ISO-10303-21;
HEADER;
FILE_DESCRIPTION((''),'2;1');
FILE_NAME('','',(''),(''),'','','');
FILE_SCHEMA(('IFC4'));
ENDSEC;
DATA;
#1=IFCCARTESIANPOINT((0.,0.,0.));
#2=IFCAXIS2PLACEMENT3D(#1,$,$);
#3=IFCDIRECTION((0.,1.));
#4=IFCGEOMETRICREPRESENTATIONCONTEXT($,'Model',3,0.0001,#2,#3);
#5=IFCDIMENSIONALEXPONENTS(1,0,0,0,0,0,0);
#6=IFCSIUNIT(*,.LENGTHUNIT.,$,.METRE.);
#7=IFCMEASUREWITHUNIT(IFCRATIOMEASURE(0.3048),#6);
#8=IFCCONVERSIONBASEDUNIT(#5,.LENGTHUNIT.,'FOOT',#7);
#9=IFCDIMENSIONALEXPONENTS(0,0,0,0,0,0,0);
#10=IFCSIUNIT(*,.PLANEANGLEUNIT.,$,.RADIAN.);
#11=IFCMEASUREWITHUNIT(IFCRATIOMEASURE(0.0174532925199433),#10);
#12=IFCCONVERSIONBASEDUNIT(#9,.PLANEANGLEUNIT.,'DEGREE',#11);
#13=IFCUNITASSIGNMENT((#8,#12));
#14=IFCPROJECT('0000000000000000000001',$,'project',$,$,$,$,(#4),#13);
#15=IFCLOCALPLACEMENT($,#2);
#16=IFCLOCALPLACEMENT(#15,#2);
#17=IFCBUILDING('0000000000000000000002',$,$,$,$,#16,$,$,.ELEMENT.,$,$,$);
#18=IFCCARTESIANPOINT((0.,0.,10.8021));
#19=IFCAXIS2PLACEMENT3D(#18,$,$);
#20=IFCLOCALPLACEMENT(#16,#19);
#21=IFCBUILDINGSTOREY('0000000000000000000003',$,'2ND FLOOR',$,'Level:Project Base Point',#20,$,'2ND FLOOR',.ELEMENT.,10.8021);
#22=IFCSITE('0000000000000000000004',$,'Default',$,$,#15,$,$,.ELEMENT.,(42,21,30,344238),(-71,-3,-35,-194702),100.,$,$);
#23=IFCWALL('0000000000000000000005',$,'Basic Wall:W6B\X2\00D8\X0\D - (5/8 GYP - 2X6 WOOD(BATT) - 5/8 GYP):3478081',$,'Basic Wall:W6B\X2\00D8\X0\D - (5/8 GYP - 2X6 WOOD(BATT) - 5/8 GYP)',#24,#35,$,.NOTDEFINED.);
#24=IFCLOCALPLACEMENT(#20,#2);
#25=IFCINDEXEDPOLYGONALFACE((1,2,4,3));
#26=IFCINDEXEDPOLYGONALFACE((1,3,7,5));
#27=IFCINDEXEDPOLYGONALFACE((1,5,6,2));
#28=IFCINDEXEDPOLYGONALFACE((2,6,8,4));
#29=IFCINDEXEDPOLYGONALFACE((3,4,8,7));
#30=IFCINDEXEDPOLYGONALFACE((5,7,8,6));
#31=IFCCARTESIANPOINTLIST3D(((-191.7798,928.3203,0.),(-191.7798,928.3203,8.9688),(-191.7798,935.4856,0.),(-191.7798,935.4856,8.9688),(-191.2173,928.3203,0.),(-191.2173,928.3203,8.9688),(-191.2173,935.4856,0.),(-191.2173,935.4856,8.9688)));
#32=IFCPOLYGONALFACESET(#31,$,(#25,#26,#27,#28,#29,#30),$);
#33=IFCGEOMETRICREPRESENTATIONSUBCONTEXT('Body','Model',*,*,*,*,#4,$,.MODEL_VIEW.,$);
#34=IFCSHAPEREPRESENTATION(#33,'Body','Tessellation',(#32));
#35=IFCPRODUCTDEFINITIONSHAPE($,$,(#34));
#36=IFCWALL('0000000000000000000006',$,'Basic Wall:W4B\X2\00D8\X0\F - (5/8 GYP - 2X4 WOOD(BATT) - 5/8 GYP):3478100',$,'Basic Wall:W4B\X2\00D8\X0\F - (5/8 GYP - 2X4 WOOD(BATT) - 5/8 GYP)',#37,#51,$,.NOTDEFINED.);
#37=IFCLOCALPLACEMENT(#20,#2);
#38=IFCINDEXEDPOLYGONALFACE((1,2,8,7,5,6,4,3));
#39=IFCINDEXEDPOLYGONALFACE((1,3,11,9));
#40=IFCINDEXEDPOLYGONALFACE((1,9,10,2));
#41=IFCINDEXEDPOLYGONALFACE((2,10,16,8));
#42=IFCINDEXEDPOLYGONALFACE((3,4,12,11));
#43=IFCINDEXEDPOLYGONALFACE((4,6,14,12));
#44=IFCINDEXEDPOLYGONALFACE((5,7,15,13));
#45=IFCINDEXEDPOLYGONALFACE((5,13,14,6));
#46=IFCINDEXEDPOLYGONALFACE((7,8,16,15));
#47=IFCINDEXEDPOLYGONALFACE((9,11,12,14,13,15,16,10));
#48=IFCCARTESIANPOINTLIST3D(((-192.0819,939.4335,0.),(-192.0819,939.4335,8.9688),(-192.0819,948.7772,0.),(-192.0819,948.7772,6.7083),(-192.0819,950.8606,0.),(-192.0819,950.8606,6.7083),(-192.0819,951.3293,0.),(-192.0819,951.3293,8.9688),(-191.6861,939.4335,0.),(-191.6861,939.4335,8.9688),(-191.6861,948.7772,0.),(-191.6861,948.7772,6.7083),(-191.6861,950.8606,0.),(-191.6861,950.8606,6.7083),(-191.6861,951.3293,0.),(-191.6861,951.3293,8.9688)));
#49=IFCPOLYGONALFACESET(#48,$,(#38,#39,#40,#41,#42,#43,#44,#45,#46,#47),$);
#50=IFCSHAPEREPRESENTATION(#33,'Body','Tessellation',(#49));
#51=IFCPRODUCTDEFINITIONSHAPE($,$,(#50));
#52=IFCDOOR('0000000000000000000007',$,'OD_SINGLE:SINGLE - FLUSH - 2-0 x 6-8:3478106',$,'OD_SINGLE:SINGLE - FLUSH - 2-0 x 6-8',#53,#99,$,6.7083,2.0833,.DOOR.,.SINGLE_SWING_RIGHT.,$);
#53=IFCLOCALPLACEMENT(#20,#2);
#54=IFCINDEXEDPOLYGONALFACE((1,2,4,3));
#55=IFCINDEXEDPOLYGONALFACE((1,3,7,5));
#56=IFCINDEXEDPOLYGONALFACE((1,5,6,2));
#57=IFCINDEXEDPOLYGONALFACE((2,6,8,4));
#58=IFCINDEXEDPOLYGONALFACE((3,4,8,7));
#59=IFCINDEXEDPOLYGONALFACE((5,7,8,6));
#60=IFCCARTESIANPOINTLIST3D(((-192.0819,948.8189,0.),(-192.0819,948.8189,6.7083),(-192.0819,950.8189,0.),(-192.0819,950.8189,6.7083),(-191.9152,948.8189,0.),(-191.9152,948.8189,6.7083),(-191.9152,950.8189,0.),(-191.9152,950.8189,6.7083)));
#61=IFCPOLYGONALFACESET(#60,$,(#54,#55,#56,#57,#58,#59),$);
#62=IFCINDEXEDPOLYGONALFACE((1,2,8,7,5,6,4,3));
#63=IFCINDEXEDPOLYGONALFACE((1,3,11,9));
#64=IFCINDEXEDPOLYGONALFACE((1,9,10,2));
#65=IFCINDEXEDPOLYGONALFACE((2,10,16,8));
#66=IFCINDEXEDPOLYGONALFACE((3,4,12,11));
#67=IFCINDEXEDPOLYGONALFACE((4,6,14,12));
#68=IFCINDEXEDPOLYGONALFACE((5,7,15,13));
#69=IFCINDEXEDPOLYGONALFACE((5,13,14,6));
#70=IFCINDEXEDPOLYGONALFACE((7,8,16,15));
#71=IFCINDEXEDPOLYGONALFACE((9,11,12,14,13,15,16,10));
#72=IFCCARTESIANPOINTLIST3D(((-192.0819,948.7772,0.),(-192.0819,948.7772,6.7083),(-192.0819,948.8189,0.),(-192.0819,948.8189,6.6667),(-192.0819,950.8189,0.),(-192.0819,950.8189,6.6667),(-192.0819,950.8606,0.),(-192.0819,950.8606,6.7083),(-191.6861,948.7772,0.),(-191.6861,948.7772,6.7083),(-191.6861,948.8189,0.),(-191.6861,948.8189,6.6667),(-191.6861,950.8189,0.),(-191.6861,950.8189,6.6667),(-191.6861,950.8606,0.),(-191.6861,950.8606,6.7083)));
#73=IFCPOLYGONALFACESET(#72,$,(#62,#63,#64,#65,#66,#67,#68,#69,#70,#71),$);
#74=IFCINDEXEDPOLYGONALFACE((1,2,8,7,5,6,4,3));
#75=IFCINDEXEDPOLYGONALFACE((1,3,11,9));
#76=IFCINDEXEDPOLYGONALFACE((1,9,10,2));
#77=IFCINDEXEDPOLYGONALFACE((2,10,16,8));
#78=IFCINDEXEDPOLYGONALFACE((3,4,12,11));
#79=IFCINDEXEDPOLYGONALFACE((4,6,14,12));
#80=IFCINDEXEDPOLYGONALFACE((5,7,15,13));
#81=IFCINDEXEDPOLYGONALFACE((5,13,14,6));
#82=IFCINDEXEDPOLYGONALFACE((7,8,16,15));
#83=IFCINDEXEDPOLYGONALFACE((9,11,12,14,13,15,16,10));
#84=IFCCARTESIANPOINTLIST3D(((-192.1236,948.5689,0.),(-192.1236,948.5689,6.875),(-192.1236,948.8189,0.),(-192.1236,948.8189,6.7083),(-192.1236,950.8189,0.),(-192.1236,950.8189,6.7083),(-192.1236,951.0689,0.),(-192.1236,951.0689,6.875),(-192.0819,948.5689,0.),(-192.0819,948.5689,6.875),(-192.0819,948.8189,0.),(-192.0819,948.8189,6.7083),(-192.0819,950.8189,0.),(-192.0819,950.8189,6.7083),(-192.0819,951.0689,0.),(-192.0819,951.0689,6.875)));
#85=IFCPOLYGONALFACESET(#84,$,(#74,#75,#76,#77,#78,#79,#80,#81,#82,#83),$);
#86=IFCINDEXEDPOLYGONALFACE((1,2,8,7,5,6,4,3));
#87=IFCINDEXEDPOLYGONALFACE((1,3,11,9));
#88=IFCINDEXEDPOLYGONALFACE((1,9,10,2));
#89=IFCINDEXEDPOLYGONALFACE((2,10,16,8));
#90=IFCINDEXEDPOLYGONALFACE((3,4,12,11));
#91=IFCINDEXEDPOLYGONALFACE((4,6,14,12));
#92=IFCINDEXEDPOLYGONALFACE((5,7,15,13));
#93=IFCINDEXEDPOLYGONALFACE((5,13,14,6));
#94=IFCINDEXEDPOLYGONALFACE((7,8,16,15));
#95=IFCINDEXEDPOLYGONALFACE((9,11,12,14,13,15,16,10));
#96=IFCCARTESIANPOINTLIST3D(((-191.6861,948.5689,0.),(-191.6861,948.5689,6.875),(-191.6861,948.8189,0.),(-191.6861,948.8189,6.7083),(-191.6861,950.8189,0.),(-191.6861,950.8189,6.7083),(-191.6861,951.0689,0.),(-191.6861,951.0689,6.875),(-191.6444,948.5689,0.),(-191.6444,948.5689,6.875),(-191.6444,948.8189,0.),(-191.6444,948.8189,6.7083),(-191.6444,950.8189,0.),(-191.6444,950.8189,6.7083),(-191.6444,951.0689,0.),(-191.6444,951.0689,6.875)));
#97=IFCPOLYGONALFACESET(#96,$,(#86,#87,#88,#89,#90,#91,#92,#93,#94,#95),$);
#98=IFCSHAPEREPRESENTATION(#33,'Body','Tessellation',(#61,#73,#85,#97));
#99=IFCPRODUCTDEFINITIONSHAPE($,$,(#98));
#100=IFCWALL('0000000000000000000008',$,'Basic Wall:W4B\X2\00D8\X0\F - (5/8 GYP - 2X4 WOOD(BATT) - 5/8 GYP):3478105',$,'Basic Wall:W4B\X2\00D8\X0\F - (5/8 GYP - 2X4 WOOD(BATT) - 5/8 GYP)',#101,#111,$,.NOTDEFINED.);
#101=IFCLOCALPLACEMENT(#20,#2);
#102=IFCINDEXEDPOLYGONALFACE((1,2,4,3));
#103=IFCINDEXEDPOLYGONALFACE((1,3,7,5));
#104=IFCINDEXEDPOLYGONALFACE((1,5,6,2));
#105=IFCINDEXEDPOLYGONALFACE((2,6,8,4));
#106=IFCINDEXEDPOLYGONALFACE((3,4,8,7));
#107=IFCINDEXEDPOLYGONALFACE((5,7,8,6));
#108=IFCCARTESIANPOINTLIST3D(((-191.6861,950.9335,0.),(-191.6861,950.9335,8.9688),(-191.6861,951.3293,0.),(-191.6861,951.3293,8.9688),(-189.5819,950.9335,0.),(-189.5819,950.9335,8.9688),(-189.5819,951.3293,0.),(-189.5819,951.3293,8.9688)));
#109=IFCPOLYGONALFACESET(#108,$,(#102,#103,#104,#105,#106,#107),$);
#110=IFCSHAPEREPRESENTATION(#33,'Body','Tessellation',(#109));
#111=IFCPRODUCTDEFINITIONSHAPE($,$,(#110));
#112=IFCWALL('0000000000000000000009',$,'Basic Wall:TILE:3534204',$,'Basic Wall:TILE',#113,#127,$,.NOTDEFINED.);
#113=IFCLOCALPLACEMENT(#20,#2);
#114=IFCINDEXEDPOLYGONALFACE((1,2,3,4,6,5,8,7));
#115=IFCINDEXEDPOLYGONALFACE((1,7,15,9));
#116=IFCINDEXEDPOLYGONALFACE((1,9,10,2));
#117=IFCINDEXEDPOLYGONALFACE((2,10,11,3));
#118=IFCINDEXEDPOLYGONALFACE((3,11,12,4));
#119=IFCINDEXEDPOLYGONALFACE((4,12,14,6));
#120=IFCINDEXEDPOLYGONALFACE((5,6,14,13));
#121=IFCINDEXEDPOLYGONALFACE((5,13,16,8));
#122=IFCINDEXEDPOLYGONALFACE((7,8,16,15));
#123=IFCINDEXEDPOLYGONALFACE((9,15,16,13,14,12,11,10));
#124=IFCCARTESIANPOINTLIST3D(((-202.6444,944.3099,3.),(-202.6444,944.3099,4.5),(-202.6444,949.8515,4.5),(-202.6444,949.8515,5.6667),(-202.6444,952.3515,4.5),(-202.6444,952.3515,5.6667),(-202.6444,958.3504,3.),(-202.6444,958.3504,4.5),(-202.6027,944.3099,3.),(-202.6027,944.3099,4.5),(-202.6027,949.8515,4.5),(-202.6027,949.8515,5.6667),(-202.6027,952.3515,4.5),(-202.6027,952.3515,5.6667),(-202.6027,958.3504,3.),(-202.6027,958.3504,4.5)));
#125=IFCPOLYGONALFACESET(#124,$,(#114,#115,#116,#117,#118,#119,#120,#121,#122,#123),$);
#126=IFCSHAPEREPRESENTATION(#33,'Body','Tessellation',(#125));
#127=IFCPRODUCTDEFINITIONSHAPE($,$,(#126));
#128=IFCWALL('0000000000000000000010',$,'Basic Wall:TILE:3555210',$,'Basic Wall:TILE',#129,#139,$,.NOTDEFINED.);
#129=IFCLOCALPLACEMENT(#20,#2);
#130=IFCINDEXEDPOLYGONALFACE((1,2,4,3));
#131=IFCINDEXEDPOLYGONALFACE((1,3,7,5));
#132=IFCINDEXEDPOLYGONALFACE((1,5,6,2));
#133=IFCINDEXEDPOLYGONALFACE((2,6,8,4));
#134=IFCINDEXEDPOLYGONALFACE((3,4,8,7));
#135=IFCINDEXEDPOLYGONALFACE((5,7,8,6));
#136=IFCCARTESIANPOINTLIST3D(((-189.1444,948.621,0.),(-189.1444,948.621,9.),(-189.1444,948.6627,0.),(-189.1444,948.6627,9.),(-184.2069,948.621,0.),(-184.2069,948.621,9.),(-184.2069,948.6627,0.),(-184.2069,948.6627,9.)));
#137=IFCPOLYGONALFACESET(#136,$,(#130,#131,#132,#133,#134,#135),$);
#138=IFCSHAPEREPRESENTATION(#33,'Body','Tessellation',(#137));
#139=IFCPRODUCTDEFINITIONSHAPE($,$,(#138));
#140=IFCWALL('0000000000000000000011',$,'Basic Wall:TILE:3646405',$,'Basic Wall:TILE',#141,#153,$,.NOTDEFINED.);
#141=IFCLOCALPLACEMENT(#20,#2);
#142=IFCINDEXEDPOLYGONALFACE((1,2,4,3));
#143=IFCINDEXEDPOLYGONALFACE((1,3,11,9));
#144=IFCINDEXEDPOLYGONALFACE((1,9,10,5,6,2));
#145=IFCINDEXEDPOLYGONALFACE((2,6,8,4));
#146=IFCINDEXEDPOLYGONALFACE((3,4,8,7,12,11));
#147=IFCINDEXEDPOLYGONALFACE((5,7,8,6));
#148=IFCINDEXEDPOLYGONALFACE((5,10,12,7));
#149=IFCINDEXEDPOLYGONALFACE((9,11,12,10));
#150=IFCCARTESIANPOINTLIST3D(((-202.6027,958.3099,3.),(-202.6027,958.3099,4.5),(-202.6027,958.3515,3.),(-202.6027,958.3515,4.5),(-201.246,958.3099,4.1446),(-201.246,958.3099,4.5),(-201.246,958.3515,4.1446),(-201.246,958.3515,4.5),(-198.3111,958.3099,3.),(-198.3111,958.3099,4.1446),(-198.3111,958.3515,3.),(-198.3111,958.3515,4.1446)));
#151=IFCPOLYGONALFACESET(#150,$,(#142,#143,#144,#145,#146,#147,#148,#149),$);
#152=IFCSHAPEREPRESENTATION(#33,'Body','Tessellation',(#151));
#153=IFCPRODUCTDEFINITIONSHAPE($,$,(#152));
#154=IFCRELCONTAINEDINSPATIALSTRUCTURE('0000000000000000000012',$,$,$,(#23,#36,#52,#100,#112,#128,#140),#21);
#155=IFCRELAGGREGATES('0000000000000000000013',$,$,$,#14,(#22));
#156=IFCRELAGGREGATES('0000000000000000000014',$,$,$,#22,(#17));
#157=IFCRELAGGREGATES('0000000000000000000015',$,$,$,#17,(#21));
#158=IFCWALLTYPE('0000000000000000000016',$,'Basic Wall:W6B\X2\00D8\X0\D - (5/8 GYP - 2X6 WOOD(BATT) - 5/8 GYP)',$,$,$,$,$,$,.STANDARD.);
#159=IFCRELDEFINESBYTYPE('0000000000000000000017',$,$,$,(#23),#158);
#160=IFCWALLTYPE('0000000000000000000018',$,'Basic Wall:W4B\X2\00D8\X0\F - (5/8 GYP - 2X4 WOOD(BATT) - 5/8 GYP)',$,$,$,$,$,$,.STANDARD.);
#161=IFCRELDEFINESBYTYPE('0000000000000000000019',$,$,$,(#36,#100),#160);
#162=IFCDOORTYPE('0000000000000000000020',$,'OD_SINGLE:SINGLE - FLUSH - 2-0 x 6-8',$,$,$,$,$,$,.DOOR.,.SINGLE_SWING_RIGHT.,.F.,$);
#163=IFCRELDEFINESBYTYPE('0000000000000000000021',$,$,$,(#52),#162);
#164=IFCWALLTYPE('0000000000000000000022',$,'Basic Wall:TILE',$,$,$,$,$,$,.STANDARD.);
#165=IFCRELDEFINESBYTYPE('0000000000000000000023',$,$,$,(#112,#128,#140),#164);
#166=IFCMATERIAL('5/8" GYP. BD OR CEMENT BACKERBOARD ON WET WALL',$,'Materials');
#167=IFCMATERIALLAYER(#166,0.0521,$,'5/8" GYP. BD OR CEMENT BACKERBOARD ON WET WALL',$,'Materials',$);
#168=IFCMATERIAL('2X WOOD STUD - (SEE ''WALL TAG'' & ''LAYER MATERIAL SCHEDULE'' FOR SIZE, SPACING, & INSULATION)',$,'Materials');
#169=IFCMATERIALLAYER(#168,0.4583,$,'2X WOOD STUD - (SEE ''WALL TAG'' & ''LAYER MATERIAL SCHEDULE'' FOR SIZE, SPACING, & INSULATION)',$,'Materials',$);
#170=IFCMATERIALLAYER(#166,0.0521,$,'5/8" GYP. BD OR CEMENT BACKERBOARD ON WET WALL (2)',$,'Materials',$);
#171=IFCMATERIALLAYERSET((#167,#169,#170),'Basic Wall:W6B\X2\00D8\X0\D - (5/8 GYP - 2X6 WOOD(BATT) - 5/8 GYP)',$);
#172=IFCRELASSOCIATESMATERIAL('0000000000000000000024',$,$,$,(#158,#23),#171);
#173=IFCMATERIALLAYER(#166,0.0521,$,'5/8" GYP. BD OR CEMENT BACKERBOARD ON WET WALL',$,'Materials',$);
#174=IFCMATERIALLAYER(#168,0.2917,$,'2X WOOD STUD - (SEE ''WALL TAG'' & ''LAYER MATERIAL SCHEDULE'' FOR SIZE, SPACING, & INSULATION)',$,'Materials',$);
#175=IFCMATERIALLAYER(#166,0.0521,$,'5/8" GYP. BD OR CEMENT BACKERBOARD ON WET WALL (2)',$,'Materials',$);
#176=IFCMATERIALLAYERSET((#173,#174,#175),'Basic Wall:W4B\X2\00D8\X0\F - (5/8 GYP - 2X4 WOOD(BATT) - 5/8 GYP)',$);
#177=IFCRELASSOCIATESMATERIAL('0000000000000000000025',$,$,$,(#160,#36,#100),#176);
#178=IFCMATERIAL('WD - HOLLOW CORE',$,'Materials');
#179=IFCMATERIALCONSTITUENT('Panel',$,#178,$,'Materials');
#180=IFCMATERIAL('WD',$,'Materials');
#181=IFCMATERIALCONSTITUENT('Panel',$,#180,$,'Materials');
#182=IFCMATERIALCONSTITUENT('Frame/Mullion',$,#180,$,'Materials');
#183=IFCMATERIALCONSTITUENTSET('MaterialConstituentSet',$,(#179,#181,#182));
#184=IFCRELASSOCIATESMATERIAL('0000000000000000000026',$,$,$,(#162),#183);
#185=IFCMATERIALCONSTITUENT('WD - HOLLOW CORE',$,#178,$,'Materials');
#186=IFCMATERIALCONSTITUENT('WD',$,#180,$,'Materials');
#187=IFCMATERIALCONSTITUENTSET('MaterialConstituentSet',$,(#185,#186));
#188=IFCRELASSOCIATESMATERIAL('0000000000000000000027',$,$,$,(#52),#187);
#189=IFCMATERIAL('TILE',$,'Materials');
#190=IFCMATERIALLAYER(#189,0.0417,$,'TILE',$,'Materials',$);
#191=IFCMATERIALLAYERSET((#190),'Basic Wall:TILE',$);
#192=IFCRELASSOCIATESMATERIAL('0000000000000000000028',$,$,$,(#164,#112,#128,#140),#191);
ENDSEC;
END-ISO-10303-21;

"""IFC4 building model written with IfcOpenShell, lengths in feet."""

from ifc_helpers import new_model, entity, si_unit, converted_unit, direction, frame, frame_2d, origin, origin_2d_with_axis, place, context, subcontext, project, spatial, polyline, rectangle, outline, extrude, source, transform, mapped, material, layer, layer_set, layer_usage, constituent, constituent_set, type_object, type_shapes, element, fill, save


model = new_model("IFC4")

# Units and contexts
model_context = context("Model", 3, precision=0.0001, world=origin(), true_north=direction((0.0, 1.0)))
body_context = subcontext(model_context, "Body", "Model", "MODEL_VIEW")
ifc_project = project(units=[converted_unit("LENGTHUNIT", "FOOT", entity("IfcRatioMeasure", 0.3048), si_unit("LENGTHUNIT", "METRE"), dimensions=[1, 0, 0, 0, 0, 0, 0]), converted_unit("PLANEANGLEUNIT", "DEGREE", entity("IfcRatioMeasure", 0.0174532925199433), si_unit("PLANEANGLEUNIT", "RADIAN"), dimensions=[0, 0, 0, 0, 0, 0, 0])], contexts=[model_context])

# Site, building, storey
site_placement = place(None, origin())
site = spatial("IfcSite", under=ifc_project, at=site_placement, Name="Default", CompositionType="ELEMENT", RefLatitude=(42, 21, 30, 344238), RefLongitude=(-71, -3, -35, -194702), RefElevation=100.0)
building_placement = place(site_placement, origin())
building = spatial("IfcBuilding", under=site, at=building_placement, CompositionType="ELEMENT")
storey_placement = place(building_placement, frame((0.0, 0.0, 10.8021)))
storey = spatial("IfcBuildingStorey", under=building, at=storey_placement, Name="2ND FLOOR", ObjectType="Level:Project Base Point", LongName="2ND FLOOR", CompositionType="ELEMENT", Elevation=10.8021)

# Wall
ifc_material_1 = material(Name="5/8\" GYP. BD OR CEMENT BACKERBOARD ON WET WALL", Category="Materials")
ifc_layer_1 = layer(ifc_material_1, 0.0521, Name="5/8\" GYP. BD OR CEMENT BACKERBOARD ON WET WALL", Category="Materials")
ifc_material_2 = material(Name="2X WOOD STUD - (SEE 'WALL TAG' & 'LAYER MATERIAL SCHEDULE' FOR SIZE, SPACING, & INSULATION)", Category="Materials")
ifc_layer_2 = layer(ifc_material_2, 0.4583, Name="2X WOOD STUD - (SEE 'WALL TAG' & 'LAYER MATERIAL SCHEDULE' FOR SIZE, SPACING, & INSULATION)", Category="Materials")
ifc_layer_3 = layer(ifc_material_1, 0.0521, Name="5/8\" GYP. BD OR CEMENT BACKERBOARD ON WET WALL (2)", Category="Materials")
ifc_layer_set_1 = layer_set([ifc_layer_1, ifc_layer_2, ifc_layer_3], Name="Basic Wall:W6BØD - (5/8 GYP - 2X6 WOOD(BATT) - 5/8 GYP)")
ifc_layer_usage_1 = layer_usage(ifc_layer_set_1, "AXIS2", "NEGATIVE", 0.2812)
wall_type_1 = type_object("IfcWallType", Name="Basic Wall:W6BØD - (5/8 GYP - 2X6 WOOD(BATT) - 5/8 GYP)", PredefinedType="STANDARD", material=ifc_layer_set_1)
wall_1_placement = place(storey_placement, frame((-191.4985, 928.3203, 0.0), z_axis=(0.0, 0.0, 1.0), x_axis=(0.0, 1.0, 0.0)))
element("IfcWall", 1, at=wall_1_placement, inside=storey, type_object=wall_type_1, material=ifc_layer_usage_1, Name="Basic Wall:W6BØD - (5/8 GYP - 2X6 WOOD(BATT) - 5/8 GYP):3478081", ObjectType="Basic Wall:W6BØD - (5/8 GYP - 2X6 WOOD(BATT) - 5/8 GYP)", PredefinedType="NOTDEFINED", context=body_context, shape_type="SweptSolid", body=[
    extrude(rectangle(XDim=7.1653, YDim=0.5625, at=frame_2d((3.5826, 0.0), x_axis=(-1.0, 0.0))), origin(), (0.0, 0.0, 1.0), 8.9688),
])

# Wall, opening, door
ifc_layer_4 = layer(ifc_material_1, 0.0521, Name="5/8\" GYP. BD OR CEMENT BACKERBOARD ON WET WALL", Category="Materials")
ifc_layer_5 = layer(ifc_material_2, 0.2917, Name="2X WOOD STUD - (SEE 'WALL TAG' & 'LAYER MATERIAL SCHEDULE' FOR SIZE, SPACING, & INSULATION)", Category="Materials")
ifc_layer_6 = layer(ifc_material_1, 0.0521, Name="5/8\" GYP. BD OR CEMENT BACKERBOARD ON WET WALL (2)", Category="Materials")
ifc_layer_set_2 = layer_set([ifc_layer_4, ifc_layer_5, ifc_layer_6], Name="Basic Wall:W4BØF - (5/8 GYP - 2X4 WOOD(BATT) - 5/8 GYP)")
wall_type_2 = type_object("IfcWallType", Name="Basic Wall:W4BØF - (5/8 GYP - 2X4 WOOD(BATT) - 5/8 GYP)", PredefinedType="STANDARD", material=ifc_layer_set_2)
ifc_material_3 = material(Name="WD - HOLLOW CORE", Category="Materials")
ifc_material_4 = material(Name="WD", Category="Materials")
ifc_layer_usage_2 = layer_usage(ifc_layer_set_2, "AXIS2", "NEGATIVE", 0.1979)
wall_2_placement = place(storey_placement, frame((-191.884, 939.4335, 0.0), z_axis=(0.0, 0.0, 1.0), x_axis=(0.0, 1.0, 0.0)))
wall_2 = element("IfcWall", 2, at=wall_2_placement, inside=storey, type_object=wall_type_2, material=ifc_layer_usage_2, Name="Basic Wall:W4BØF - (5/8 GYP - 2X4 WOOD(BATT) - 5/8 GYP):3478100", ObjectType="Basic Wall:W4BØF - (5/8 GYP - 2X4 WOOD(BATT) - 5/8 GYP)", PredefinedType="NOTDEFINED", context=body_context, shape_type="SweptSolid", body=[
    extrude(rectangle(XDim=11.8958, YDim=0.3958, at=frame_2d((5.9479, 0.0), x_axis=(-1.0, 0.0))), origin(), (0.0, 0.0, 1.0), 8.9688),
])
opening_1_placement = place(wall_2_placement, frame((9.3438, -0.1979, 0.0)))
opening_1 = element("IfcOpeningElement", 3, at=opening_1_placement, cuts=wall_2, PredefinedType="OPENING", context=body_context, shape_type="SweptSolid", body=[
    extrude(rectangle(XDim=2.0833, YDim=6.7083, at=frame_2d((3.3542, 1.0417), x_axis=(0.0, 1.0))), frame((0.0, 0.0, 0.0), z_axis=(0.0, 1.0, 0.0), x_axis=(0.0, 0.0, 1.0)), (0.0, 0.0, 1.0), 0.3958),
])
ifc_constituent_1 = constituent(ifc_material_3, Name="WD - HOLLOW CORE", Category="Materials")
ifc_constituent_2 = constituent(ifc_material_4, Name="WD", Category="Materials")
ifc_constituent_set_1 = constituent_set(constituents=[ifc_constituent_1, ifc_constituent_2], Name="MaterialConstituentSet")
ifc_constituent_3 = constituent(ifc_material_3, Name="Panel", Category="Materials")
ifc_constituent_4 = constituent(ifc_material_4, Name="Panel", Category="Materials")
ifc_constituent_5 = constituent(ifc_material_4, Name="Frame/Mullion", Category="Materials")
ifc_constituent_set_2 = constituent_set(constituents=[ifc_constituent_3, ifc_constituent_4, ifc_constituent_5], Name="MaterialConstituentSet")
door_type_1 = type_object("IfcDoorType", Name="OD_SINGLE:SINGLE - FLUSH - 2-0 x 6-8", OperationType="SINGLE_SWING_RIGHT", ParameterTakesPrecedence=False, PredefinedType="DOOR", material=ifc_constituent_set_2)
shared_shape_1 = source(origin(), body_context, "Body", "SweptSolid", [
    extrude(rectangle(XDim=0.1667, YDim=2.0, at=origin_2d_with_axis()), frame((1.0417, 0.3125, 0.0), z_axis=(0.0, 0.0, 1.0), x_axis=(0.0, 1.0, 0.0)), (0.0, 0.0, 1.0), 6.7083),
    extrude(outline(polyline([(-3.3646, -1.0417), (3.3438, -1.0417), (3.3438, -1.0), (-3.3229, -1.0), (-3.3229, 1.0), (3.3438, 1.0), (3.3438, 1.0417), (-3.3646, 1.0417), (-3.3646, -1.0417)])), frame((1.0417, 0.0, 3.3438), z_axis=(0.0, 1.0, 0.0), x_axis=(0.0, 0.0, -1.0)), (0.0, 0.0, 1.0), 0.3958),
    extrude(outline(polyline([(-1.25, -3.4792), (1.25, -3.4792), (1.25, 3.3958), (1.0, 3.3958), (1.0, -3.3125), (-1.0, -3.3125), (-1.0, 3.3958), (-1.25, 3.3958), (-1.25, -3.4792)])), frame((1.0417, 0.3958, 3.3958), z_axis=(0.0, 1.0, 0.0), x_axis=(1.0, 0.0, 0.0)), (0.0, 0.0, 1.0), 0.0417),
    extrude(outline(polyline([(-3.4792, -1.25), (3.3958, -1.25), (3.3958, -1.0), (-3.3125, -1.0), (-3.3125, 1.0), (3.3958, 1.0), (3.3958, 1.25), (-3.4792, 1.25), (-3.4792, -1.25)])), frame((1.0417, -0.0417, 3.3958), z_axis=(0.0, 1.0, 0.0), x_axis=(0.0, 0.0, -1.0)), (0.0, 0.0, 1.0), 0.0417),
])
type_shapes(door_type_1, [shared_shape_1])
door_1_placement = place(opening_1_placement, origin())
door_1 = element("IfcDoor", 4, at=door_1_placement, inside=storey, type_object=door_type_1, material=ifc_constituent_set_1, Name="OD_SINGLE:SINGLE - FLUSH - 2-0 x 6-8:3478106", ObjectType="OD_SINGLE:SINGLE - FLUSH - 2-0 x 6-8", OperationType="SINGLE_SWING_RIGHT", OverallHeight=6.7083, OverallWidth=2.0833, PredefinedType="DOOR", context=body_context, shape_type="MappedRepresentation", body=[
    mapped(shared_shape_1, transform((0.0, 0.0, 0.0), scale=1.0)),
])
fill(opening_1, door_1)

# Wall
ifc_layer_usage_3 = layer_usage(ifc_layer_set_2, "AXIS2", "POSITIVE", -0.1979)
wall_3_placement = place(storey_placement, frame((-189.5819, 951.1314, 0.0), z_axis=(0.0, 0.0, 1.0), x_axis=(-1.0, 0.0, 0.0)))
element("IfcWall", 5, at=wall_3_placement, inside=storey, type_object=wall_type_2, material=ifc_layer_usage_3, Name="Basic Wall:W4BØF - (5/8 GYP - 2X4 WOOD(BATT) - 5/8 GYP):3478105", ObjectType="Basic Wall:W4BØF - (5/8 GYP - 2X4 WOOD(BATT) - 5/8 GYP)", PredefinedType="NOTDEFINED", context=body_context, shape_type="SweptSolid", body=[
    extrude(rectangle(XDim=2.1042, YDim=0.3958, at=frame_2d((1.0521, 0.0), x_axis=(-1.0, 0.0))), origin(), (0.0, 0.0, 1.0), 8.9688),
])

# Wall, openings
ifc_material_5 = material(Name="TILE", Category="Materials")
ifc_layer_7 = layer(ifc_material_5, 0.0417, Name="TILE", Category="Materials")
ifc_layer_set_3 = layer_set([ifc_layer_7], Name="Basic Wall:TILE")
ifc_layer_usage_4 = layer_usage(ifc_layer_set_3, "AXIS2", "POSITIVE", -0.0208)
wall_type_3 = type_object("IfcWallType", Name="Basic Wall:TILE", PredefinedType="STANDARD", material=ifc_layer_set_3)
wall_4_placement = place(storey_placement, frame((-202.6236, 958.3504, 3.0), z_axis=(0.0, 0.0, 1.0), x_axis=(0.0, -1.0, 0.0)))
wall_4 = element("IfcWall", 6, at=wall_4_placement, inside=storey, type_object=wall_type_3, material=ifc_layer_usage_4, Name="Basic Wall:TILE:3534204", ObjectType="Basic Wall:TILE", PredefinedType="NOTDEFINED", context=body_context, shape_type="SweptSolid", body=[
    extrude(rectangle(XDim=14.0406, YDim=0.0417, at=frame_2d((7.0203, 0.0), x_axis=(-1.0, 0.0))), origin(), (0.0, 0.0, 1.0), 2.6667),
])
opening_2_placement = place(wall_4_placement, origin())
element("IfcOpeningElement", 7, at=opening_2_placement, cuts=wall_4, PredefinedType="OPENING", context=body_context, shape_type="SweptSolid", body=[
    extrude(rectangle(XDim=1.1667, YDim=5.5417, at=frame_2d((0.0, 0.0), x_axis=(1.0, 0.0))), frame((11.2697, 0.0208, 2.0833), z_axis=(0.0, -1.0, 0.0), x_axis=(0.0, 0.0, 1.0)), (0.0, 0.0, 1.0), 0.0417),
])
opening_3_placement = place(wall_4_placement, origin())
element("IfcOpeningElement", 8, at=opening_3_placement, cuts=wall_4, PredefinedType="OPENING", context=body_context, shape_type="SweptSolid", body=[
    extrude(rectangle(XDim=1.1667, YDim=5.9989, at=frame_2d((0.0, 0.0), x_axis=(0.0, 1.0))), frame((2.9994, 0.0208, 2.0833), z_axis=(0.0, -1.0, 0.0), x_axis=(-1.0, 0.0, 0.0)), (0.0, 0.0, 1.0), 0.0417),
])

# Wall
ifc_layer_usage_5 = layer_usage(ifc_layer_set_3, "AXIS2", "POSITIVE", -0.0208)
wall_5_placement = place(storey_placement, frame((-189.1444, 948.6418, 0.0)))
element("IfcWall", 9, at=wall_5_placement, inside=storey, type_object=wall_type_3, material=ifc_layer_usage_5, Name="Basic Wall:TILE:3555210", ObjectType="Basic Wall:TILE", PredefinedType="NOTDEFINED", context=body_context, shape_type="SweptSolid", body=[
    extrude(rectangle(XDim=4.9375, YDim=0.0417, at=frame_2d((2.4688, 0.0), x_axis=(-1.0, 0.0))), origin(), (0.0, 0.0, 1.0), 9.0),
])

# Wall, opening
ifc_layer_usage_6 = layer_usage(ifc_layer_set_3, "AXIS2", "NEGATIVE", 0.0208)
wall_6_placement = place(storey_placement, frame((-202.6027, 958.3307, 3.0)))
wall_6 = element("IfcWall", 10, at=wall_6_placement, inside=storey, type_object=wall_type_3, material=ifc_layer_usage_6, Name="Basic Wall:TILE:3646405", ObjectType="Basic Wall:TILE", PredefinedType="NOTDEFINED", context=body_context, shape_type="SweptSolid", body=[
    extrude(rectangle(XDim=4.2917, YDim=0.0417, at=frame_2d((2.1458, 0.0), x_axis=(-1.0, 0.0))), origin(), (0.0, 0.0, 1.0), 1.5),
])
opening_4_placement = place(wall_6_placement, origin())
element("IfcOpeningElement", 11, at=opening_4_placement, cuts=wall_6, PredefinedType="OPENING", context=body_context, shape_type="SweptSolid", body=[
    extrude(rectangle(XDim=0.3554, YDim=2.9349, at=frame_2d((0.0, 0.0), x_axis=(1.0, 0.0))), frame((2.8242, 0.0208, 1.3223), z_axis=(0.0, -1.0, 0.0), x_axis=(0.0, 0.0, 1.0)), (0.0, 0.0, 1.0), 0.0417),
])

save(model, "model.ifc")
